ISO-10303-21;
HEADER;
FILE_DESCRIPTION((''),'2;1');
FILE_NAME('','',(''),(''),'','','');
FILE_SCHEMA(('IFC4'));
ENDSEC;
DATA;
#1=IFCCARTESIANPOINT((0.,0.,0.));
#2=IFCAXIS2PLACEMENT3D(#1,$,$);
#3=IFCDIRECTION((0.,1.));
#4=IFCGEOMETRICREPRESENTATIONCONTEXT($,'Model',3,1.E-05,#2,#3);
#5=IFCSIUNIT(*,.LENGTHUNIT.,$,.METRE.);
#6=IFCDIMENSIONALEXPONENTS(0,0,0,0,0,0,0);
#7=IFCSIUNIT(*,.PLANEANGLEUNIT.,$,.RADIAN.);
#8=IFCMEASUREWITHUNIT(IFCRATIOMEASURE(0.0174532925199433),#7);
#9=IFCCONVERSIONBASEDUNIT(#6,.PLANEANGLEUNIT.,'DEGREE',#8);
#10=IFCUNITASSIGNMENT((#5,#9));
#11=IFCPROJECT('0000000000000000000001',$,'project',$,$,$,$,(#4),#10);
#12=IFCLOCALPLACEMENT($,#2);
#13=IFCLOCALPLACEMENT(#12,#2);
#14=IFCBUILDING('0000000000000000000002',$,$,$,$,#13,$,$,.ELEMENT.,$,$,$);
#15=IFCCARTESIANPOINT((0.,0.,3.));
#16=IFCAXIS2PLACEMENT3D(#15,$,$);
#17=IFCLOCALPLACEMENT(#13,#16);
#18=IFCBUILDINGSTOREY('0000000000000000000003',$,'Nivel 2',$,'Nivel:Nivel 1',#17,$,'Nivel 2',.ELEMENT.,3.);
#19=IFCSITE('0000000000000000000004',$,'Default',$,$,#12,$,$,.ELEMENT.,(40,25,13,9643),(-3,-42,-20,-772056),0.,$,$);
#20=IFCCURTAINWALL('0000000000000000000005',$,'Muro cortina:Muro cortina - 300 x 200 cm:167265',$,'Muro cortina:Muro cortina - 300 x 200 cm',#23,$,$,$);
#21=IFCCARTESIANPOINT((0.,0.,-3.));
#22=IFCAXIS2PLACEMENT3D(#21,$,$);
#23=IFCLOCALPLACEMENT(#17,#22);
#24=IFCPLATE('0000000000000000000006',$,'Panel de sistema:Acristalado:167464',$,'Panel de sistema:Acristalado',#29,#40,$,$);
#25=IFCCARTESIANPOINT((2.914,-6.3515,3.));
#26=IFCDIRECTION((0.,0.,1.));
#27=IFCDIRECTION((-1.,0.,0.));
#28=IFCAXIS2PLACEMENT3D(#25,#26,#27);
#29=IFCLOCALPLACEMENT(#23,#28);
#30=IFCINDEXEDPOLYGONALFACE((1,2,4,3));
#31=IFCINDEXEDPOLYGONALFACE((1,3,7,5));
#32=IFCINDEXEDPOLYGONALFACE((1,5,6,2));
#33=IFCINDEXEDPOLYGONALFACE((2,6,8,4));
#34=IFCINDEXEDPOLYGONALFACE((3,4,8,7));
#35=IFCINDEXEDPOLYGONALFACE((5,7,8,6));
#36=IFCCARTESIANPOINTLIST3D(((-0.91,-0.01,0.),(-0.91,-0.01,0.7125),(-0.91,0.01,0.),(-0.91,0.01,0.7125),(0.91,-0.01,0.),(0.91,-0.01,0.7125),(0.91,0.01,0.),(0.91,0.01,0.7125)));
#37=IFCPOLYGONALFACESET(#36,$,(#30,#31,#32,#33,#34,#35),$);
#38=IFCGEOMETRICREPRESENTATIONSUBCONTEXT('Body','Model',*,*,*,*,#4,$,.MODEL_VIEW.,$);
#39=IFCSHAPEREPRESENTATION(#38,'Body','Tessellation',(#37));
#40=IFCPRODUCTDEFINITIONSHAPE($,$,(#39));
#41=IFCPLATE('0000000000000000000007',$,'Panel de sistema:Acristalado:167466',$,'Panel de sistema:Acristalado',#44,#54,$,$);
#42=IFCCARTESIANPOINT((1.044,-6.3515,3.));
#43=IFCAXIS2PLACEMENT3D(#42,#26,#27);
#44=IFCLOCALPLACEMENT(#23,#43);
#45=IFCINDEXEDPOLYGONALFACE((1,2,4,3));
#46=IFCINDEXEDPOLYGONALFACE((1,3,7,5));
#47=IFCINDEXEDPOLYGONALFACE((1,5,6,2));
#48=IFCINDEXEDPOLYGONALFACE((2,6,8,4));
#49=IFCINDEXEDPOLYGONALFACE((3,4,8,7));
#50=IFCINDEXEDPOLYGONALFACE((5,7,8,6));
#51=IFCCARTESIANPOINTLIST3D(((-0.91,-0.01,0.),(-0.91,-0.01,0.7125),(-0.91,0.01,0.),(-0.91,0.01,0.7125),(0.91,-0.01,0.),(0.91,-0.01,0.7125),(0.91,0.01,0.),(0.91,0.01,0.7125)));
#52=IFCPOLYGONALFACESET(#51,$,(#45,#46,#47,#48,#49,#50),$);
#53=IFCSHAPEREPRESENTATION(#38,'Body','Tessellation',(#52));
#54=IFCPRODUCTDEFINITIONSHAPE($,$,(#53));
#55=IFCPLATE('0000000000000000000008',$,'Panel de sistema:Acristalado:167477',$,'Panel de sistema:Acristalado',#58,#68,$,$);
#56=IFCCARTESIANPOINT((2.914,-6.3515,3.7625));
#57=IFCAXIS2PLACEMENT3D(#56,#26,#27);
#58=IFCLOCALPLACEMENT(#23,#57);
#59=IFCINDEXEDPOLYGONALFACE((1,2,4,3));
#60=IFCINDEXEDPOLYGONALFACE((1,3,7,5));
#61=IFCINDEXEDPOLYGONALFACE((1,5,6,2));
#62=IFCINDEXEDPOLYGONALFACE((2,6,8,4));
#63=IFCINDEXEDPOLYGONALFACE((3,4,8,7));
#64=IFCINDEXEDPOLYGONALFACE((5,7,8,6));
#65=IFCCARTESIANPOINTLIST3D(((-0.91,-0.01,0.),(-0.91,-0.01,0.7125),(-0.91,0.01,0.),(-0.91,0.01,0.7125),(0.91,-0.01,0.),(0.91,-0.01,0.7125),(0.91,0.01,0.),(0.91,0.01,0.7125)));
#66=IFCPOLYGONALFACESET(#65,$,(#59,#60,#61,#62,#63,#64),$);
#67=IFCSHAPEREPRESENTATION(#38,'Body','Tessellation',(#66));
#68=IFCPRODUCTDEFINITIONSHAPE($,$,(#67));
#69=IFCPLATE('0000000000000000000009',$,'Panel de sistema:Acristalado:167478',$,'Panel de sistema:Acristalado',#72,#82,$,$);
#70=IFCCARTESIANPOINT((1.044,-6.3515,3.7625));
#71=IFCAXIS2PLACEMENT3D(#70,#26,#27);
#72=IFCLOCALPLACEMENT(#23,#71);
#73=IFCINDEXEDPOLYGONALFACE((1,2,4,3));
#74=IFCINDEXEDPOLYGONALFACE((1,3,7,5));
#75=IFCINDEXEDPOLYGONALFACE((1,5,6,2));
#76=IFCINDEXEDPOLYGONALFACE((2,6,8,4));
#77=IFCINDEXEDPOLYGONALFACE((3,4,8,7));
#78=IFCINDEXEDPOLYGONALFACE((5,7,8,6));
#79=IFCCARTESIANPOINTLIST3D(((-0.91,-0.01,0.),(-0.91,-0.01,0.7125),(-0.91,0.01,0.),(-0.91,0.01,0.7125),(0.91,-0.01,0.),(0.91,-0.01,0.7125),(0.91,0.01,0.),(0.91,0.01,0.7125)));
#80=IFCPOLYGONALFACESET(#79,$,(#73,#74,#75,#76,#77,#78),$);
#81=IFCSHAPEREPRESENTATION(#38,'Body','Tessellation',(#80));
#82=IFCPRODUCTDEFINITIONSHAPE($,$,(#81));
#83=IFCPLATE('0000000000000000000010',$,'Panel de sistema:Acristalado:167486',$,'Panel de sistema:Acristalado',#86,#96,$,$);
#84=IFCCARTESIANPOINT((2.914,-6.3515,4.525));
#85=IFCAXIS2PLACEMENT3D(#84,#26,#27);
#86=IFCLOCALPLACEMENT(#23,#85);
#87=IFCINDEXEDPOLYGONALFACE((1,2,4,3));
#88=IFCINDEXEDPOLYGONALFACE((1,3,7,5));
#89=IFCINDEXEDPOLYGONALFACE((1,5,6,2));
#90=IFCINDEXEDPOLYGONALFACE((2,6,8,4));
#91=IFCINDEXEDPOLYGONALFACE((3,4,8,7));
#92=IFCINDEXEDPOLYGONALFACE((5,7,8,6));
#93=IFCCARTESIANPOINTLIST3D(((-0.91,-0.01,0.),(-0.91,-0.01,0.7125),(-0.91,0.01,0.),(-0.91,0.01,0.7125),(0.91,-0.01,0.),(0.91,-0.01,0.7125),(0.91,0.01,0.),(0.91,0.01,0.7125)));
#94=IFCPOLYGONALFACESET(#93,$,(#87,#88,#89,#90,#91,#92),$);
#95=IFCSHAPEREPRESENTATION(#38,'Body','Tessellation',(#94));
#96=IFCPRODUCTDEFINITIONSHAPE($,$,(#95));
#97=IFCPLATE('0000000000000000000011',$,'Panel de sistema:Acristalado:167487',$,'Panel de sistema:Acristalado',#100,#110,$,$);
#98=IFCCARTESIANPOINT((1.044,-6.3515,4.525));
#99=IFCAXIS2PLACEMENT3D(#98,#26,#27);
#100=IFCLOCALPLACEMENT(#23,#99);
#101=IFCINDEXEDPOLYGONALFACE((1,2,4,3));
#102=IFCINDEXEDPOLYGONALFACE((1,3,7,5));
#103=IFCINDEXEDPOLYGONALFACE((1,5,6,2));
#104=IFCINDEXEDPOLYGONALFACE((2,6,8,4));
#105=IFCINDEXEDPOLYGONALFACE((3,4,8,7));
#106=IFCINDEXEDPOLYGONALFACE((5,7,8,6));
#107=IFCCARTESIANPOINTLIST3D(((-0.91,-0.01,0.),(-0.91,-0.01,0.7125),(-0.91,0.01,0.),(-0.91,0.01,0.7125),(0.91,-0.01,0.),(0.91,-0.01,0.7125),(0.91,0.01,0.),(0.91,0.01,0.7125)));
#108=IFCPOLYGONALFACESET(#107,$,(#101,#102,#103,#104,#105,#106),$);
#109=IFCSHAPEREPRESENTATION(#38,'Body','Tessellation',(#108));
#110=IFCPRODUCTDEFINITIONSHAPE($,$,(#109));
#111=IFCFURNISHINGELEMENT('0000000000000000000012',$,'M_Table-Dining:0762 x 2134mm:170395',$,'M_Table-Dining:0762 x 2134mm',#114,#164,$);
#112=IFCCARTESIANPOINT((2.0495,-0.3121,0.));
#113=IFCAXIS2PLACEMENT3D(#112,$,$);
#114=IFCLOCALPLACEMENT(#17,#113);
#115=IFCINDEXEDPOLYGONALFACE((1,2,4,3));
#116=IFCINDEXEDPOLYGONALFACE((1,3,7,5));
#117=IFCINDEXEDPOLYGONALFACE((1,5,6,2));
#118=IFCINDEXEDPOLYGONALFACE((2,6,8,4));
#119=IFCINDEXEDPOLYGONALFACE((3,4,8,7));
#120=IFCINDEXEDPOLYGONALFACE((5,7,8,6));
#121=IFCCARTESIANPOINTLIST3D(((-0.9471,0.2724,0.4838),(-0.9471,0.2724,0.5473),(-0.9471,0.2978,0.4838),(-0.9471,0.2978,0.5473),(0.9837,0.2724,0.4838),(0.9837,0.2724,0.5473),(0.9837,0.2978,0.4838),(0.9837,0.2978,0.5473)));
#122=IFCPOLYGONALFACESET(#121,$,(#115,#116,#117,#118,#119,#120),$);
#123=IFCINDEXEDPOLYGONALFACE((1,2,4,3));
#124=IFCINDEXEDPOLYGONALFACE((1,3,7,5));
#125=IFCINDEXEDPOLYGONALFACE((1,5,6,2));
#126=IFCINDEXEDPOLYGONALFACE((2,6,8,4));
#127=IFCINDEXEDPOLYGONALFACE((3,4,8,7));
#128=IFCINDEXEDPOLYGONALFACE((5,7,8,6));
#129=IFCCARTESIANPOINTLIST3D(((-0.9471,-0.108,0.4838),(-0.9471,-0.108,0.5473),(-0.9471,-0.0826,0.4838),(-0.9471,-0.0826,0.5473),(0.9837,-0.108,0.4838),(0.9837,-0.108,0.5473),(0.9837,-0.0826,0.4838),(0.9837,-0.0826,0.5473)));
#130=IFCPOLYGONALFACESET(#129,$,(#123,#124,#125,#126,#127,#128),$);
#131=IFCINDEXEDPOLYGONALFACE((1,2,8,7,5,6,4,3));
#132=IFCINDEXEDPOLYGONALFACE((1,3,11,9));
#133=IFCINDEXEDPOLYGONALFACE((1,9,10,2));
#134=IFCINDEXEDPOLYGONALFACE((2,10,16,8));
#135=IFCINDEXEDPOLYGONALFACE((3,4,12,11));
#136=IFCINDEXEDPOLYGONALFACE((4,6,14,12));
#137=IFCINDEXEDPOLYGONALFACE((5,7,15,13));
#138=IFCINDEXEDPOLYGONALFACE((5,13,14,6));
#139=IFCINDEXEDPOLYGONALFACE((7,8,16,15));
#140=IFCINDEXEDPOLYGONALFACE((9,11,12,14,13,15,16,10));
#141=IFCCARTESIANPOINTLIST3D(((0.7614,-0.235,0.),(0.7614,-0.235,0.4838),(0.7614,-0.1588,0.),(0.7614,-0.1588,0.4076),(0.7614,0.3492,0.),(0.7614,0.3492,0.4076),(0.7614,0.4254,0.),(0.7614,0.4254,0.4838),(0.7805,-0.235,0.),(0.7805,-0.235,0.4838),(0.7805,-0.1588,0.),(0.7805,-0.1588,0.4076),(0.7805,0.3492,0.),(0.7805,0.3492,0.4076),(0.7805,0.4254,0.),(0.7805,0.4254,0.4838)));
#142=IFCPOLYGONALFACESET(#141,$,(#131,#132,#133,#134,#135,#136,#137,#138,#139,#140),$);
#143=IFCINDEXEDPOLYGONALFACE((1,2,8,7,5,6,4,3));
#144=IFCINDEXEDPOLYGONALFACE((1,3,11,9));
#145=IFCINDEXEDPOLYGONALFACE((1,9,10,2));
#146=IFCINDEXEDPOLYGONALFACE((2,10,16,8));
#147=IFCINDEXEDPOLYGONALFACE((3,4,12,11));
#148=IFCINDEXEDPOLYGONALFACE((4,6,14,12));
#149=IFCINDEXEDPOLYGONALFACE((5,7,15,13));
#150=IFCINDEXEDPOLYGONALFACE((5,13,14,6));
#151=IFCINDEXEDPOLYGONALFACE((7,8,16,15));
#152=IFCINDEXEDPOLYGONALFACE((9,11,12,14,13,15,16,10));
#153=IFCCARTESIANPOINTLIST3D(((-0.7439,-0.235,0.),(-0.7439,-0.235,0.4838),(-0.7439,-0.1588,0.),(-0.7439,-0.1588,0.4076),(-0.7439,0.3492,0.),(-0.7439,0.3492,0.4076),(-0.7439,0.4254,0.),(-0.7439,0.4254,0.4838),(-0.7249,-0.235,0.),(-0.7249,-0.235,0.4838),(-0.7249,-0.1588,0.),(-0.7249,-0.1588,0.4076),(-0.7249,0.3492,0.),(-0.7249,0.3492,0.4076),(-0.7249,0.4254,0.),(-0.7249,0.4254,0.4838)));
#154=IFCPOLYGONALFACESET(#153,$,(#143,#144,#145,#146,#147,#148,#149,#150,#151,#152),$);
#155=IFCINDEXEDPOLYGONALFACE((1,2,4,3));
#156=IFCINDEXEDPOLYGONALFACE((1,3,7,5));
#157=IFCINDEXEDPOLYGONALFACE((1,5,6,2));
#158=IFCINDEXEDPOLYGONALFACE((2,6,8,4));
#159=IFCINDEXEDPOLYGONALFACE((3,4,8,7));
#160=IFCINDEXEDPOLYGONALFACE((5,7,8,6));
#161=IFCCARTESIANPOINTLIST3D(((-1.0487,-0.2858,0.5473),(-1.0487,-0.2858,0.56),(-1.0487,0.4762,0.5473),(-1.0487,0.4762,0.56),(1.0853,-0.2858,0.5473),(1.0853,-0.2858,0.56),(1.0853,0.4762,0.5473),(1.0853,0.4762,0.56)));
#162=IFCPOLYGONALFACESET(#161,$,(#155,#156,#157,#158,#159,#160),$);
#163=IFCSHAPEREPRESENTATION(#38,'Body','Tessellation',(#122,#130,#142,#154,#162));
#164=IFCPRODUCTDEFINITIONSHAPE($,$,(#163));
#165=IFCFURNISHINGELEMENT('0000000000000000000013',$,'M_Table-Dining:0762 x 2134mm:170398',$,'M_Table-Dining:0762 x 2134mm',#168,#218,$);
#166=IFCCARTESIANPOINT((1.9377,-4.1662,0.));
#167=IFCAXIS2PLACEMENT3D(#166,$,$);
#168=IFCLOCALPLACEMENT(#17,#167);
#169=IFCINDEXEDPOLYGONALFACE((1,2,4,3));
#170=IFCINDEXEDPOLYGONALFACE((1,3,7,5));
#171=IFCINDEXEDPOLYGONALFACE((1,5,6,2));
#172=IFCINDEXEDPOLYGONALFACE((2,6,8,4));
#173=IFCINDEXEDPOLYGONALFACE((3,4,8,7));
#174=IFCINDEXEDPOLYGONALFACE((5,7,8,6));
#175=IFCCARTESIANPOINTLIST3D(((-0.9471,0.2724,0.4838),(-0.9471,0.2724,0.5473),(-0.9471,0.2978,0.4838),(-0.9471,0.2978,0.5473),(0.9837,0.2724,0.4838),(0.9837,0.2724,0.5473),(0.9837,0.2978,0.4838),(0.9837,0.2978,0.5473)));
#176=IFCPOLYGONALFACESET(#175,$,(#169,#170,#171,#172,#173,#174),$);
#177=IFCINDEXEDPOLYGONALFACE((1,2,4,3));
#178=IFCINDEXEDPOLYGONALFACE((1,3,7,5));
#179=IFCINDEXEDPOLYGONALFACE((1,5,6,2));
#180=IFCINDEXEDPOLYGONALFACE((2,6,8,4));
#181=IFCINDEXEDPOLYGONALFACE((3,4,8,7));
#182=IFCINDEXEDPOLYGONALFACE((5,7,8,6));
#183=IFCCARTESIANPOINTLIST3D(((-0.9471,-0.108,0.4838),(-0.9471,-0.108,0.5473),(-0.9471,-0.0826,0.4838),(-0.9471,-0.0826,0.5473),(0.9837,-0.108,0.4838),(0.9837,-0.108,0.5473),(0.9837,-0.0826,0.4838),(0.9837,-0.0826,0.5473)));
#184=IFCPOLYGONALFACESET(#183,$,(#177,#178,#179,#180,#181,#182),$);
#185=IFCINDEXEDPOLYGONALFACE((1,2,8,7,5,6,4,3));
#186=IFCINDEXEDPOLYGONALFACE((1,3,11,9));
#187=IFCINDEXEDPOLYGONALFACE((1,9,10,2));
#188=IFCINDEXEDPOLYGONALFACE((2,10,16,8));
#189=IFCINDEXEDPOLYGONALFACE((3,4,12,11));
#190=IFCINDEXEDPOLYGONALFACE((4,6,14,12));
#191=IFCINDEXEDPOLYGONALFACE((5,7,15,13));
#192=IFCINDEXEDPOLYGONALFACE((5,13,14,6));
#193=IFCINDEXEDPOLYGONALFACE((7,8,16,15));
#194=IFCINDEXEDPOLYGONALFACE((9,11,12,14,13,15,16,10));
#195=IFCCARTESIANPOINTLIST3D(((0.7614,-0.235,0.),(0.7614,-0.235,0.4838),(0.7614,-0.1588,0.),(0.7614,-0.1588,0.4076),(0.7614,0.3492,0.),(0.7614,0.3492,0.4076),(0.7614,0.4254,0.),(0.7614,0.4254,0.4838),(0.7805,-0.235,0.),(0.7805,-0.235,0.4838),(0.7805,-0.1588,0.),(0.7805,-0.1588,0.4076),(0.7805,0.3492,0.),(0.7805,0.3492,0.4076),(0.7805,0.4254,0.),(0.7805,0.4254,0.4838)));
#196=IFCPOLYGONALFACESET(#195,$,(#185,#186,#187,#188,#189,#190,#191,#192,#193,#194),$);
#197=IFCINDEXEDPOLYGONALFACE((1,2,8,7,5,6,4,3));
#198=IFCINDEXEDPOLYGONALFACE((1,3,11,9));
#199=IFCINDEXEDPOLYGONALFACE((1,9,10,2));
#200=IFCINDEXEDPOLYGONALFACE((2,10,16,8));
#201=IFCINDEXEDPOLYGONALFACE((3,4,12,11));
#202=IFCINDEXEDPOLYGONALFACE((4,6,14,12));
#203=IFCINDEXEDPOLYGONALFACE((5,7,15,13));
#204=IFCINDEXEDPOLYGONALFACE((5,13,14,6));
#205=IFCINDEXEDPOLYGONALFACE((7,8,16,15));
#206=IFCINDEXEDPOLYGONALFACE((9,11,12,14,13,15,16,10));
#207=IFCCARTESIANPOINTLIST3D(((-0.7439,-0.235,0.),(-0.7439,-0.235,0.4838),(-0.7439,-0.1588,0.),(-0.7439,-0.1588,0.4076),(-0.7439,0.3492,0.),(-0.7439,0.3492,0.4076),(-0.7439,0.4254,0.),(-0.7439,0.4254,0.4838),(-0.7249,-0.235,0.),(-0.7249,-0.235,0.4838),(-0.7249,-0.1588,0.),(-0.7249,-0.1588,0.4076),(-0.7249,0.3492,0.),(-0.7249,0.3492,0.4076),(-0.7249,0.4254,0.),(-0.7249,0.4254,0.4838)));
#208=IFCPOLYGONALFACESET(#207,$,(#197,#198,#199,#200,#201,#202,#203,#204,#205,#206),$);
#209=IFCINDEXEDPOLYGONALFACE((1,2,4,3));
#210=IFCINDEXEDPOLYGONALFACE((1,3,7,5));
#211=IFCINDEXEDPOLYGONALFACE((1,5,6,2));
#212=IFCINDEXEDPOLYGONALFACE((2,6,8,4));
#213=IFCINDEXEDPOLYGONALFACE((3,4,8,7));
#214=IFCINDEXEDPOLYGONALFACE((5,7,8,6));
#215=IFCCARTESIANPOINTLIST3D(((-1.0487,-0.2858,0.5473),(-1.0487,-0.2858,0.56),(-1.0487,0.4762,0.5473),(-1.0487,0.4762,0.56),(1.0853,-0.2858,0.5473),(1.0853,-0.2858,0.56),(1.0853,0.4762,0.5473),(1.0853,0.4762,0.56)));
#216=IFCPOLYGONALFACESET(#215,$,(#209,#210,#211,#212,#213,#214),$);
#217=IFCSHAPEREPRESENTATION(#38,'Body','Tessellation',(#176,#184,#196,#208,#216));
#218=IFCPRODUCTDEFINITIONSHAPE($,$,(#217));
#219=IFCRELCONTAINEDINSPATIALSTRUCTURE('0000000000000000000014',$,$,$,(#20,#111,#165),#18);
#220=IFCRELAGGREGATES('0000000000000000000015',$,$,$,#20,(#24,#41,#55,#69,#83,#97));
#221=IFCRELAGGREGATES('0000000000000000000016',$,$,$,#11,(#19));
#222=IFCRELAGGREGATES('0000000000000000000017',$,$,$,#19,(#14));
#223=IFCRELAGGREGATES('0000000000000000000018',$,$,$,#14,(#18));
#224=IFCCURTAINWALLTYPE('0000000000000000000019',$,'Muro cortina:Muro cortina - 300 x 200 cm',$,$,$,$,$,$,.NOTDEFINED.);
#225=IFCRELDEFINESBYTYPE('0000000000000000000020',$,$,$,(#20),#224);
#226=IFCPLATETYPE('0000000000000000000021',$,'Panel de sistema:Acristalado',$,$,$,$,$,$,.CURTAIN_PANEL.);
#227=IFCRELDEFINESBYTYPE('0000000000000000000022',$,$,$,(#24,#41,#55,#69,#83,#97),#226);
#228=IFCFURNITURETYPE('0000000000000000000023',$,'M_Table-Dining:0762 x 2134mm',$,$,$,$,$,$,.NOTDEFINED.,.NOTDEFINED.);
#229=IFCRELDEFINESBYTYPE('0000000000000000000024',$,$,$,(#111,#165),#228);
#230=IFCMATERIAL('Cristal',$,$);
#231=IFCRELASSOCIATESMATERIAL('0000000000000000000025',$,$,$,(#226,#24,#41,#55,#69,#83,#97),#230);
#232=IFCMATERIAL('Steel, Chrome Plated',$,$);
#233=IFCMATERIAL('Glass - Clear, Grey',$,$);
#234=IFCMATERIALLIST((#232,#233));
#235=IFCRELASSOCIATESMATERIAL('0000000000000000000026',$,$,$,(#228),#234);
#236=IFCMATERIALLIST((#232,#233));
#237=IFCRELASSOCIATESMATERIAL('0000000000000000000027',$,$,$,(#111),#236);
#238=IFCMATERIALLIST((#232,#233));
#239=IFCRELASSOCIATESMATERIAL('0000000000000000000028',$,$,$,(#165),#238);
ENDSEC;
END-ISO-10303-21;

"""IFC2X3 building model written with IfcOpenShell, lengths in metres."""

from ifc_helpers import new_model, entity, si_unit, converted_unit, direction, frame, frame_2d, origin, origin_2d_with_axis, place, context, subcontext, project, spatial, polyline, rectangle, outline, extrude, source, transform, mapped, material, material_list, type_object, type_shapes, element, aggregate, save


model = new_model("IFC2X3")

# Units and contexts
model_context = context("Model", 3, precision=1e-05, world=origin(), true_north=direction((0.0, 1.0)))
body_context = subcontext(model_context, "Body", "Model", "MODEL_VIEW")
ifc_project = project(units=[si_unit("LENGTHUNIT", "METRE"), converted_unit("PLANEANGLEUNIT", "DEGREE", entity("IfcRatioMeasure", 0.0174532925199433), si_unit("PLANEANGLEUNIT", "RADIAN"), dimensions=[0, 0, 0, 0, 0, 0, 0])], contexts=[model_context])

# Site, building, storey
site_placement = place(None, origin())
site = spatial("IfcSite", under=ifc_project, at=site_placement, Name="Default", CompositionType="ELEMENT", RefLatitude=(40, 25, 13, 9643), RefLongitude=(-3, -42, -20, -772056), RefElevation=0.0)
building_placement = place(site_placement, origin())
building = spatial("IfcBuilding", under=site, at=building_placement, CompositionType="ELEMENT")
storey_placement = place(building_placement, frame((0.0, 0.0, 3.0)))
storey = spatial("IfcBuildingStorey", under=building, at=storey_placement, Name="Nivel 2", ObjectType="Nivel:Nivel 1", LongName="Nivel 2", CompositionType="ELEMENT", Elevation=3.0)

# Curtain wall, plates
curtain_wall_type = type_object("IfcCurtainWallType", Name="Muro cortina:Muro cortina - 300 x 200 cm", PredefinedType="NOTDEFINED")
curtain_wall_placement = place(storey_placement, frame((0.0, 0.0, -3.0)))
curtain_wall = element("IfcCurtainWall", 1, at=curtain_wall_placement, inside=storey, type_object=curtain_wall_type, Name="Muro cortina:Muro cortina - 300 x 200 cm:167265", ObjectType="Muro cortina:Muro cortina - 300 x 200 cm")
ifc_material_1 = material(Name="Cristal")
plate_type = type_object("IfcPlateType", Name="Panel de sistema:Acristalado", PredefinedType="CURTAIN_PANEL", material=ifc_material_1)
shared_shape_1 = source(origin(), body_context, "Body", "SweptSolid", [
    extrude(rectangle(XDim=0.02, YDim=1.82, at=origin_2d_with_axis()), frame((0.0, 0.0, 0.0), z_axis=(0.0, 0.0, 1.0), x_axis=(0.0, 1.0, 0.0)), (0.0, 0.0, 1.0), 0.7125),
])
type_shapes(plate_type, [shared_shape_1])
plate_1_placement = place(curtain_wall_placement, frame((2.914, -6.3515, 3.0), z_axis=(0.0, 0.0, 1.0), x_axis=(-1.0, 0.0, 0.0)))
plate_1 = element("IfcPlate", 2, at=plate_1_placement, type_object=plate_type, material=ifc_material_1, Name="Panel de sistema:Acristalado:167464", ObjectType="Panel de sistema:Acristalado", context=body_context, shape_type="MappedRepresentation", body=[
    mapped(shared_shape_1, transform((0.0, 0.0, 0.0), scale=1.0)),
])
plate_2_placement = place(curtain_wall_placement, frame((1.044, -6.3515, 3.0), z_axis=(0.0, 0.0, 1.0), x_axis=(-1.0, 0.0, 0.0)))
plate_2 = element("IfcPlate", 3, at=plate_2_placement, type_object=plate_type, material=ifc_material_1, Name="Panel de sistema:Acristalado:167466", ObjectType="Panel de sistema:Acristalado", context=body_context, shape_type="MappedRepresentation", body=[
    mapped(shared_shape_1, transform((0.0, 0.0, 0.0), scale=1.0)),
])
plate_3_placement = place(curtain_wall_placement, frame((2.914, -6.3515, 3.7625), z_axis=(0.0, 0.0, 1.0), x_axis=(-1.0, 0.0, 0.0)))
plate_3 = element("IfcPlate", 4, at=plate_3_placement, type_object=plate_type, material=ifc_material_1, Name="Panel de sistema:Acristalado:167477", ObjectType="Panel de sistema:Acristalado", context=body_context, shape_type="MappedRepresentation", body=[
    mapped(shared_shape_1, transform((0.0, 0.0, 0.0), scale=1.0)),
])
plate_4_placement = place(curtain_wall_placement, frame((1.044, -6.3515, 3.7625), z_axis=(0.0, 0.0, 1.0), x_axis=(-1.0, 0.0, 0.0)))
plate_4 = element("IfcPlate", 5, at=plate_4_placement, type_object=plate_type, material=ifc_material_1, Name="Panel de sistema:Acristalado:167478", ObjectType="Panel de sistema:Acristalado", context=body_context, shape_type="MappedRepresentation", body=[
    mapped(shared_shape_1, transform((0.0, 0.0, 0.0), scale=1.0)),
])
plate_5_placement = place(curtain_wall_placement, frame((2.914, -6.3515, 4.525), z_axis=(0.0, 0.0, 1.0), x_axis=(-1.0, 0.0, 0.0)))
plate_5 = element("IfcPlate", 6, at=plate_5_placement, type_object=plate_type, material=ifc_material_1, Name="Panel de sistema:Acristalado:167486", ObjectType="Panel de sistema:Acristalado", context=body_context, shape_type="MappedRepresentation", body=[
    mapped(shared_shape_1, transform((0.0, 0.0, 0.0), scale=1.0)),
])
plate_6_placement = place(curtain_wall_placement, frame((1.044, -6.3515, 4.525), z_axis=(0.0, 0.0, 1.0), x_axis=(-1.0, 0.0, 0.0)))
plate_6 = element("IfcPlate", 7, at=plate_6_placement, type_object=plate_type, material=ifc_material_1, Name="Panel de sistema:Acristalado:167487", ObjectType="Panel de sistema:Acristalado", context=body_context, shape_type="MappedRepresentation", body=[
    mapped(shared_shape_1, transform((0.0, 0.0, 0.0), scale=1.0)),
])
aggregate(curtain_wall, [plate_1, plate_2, plate_3, plate_4, plate_5, plate_6])

# Furnishing elements
ifc_material_2 = material(Name="Steel, Chrome Plated")
ifc_material_3 = material(Name="Glass - Clear, Grey")
ifc_material_list_1 = material_list([ifc_material_2, ifc_material_3])
ifc_material_list_2 = material_list([ifc_material_2, ifc_material_3])
furniture_type = type_object("IfcFurnitureType", Name="M_Table-Dining:0762 x 2134mm", material=ifc_material_list_2)
shared_shape_2 = source(origin(), body_context, "Body", "SweptSolid", [
    extrude(rectangle(XDim=1.9308, YDim=0.0254, at=frame_2d((0.0, 0.0), x_axis=(1.0, 0.0))), frame((0.0183, 0.2851, 0.4838), z_axis=(0.0, 0.0, 1.0), x_axis=(-1.0, 0.0, 0.0)), (0.0, 0.0, 1.0), 0.0635),
    extrude(rectangle(XDim=1.9308, YDim=0.0254, at=origin_2d_with_axis()), frame((0.0183, -0.0953, 0.4838), z_axis=(0.0, 0.0, 1.0), x_axis=(-1.0, 0.0, 0.0)), (0.0, 0.0, 1.0), 0.0635),
    extrude(outline(polyline([(-0.2228, -0.3302), (0.2609, -0.3302), (0.2609, 0.3302), (-0.2228, 0.3302), (-0.2228, 0.254), (0.1847, 0.254), (0.1847, -0.254), (-0.2228, -0.254), (-0.2228, -0.3302)])), frame((0.7614, 0.0952, 0.2228), z_axis=(1.0, 0.0, 0.0), x_axis=(0.0, 0.0, 1.0)), (0.0, 0.0, 1.0), 0.0191),
    extrude(outline(polyline([(-0.3302, -0.261), (0.3302, -0.261), (0.3302, 0.2228), (0.254, 0.2228), (0.254, -0.1847), (-0.254, -0.1847), (-0.254, 0.2228), (-0.3302, 0.2228), (-0.3302, -0.261)])), frame((-0.7439, 0.0952, 0.2228), z_axis=(1.0, 0.0, 0.0), x_axis=(0.0, -1.0, 0.0)), (0.0, 0.0, 1.0), 0.0191),
    extrude(rectangle(XDim=2.134, YDim=0.762, at=origin_2d_with_axis()), frame((0.0183, 0.0952, 0.5473), z_axis=(0.0, 0.0, 1.0), x_axis=(-1.0, 0.0, 0.0)), (0.0, 0.0, 1.0), 0.0127),
])
type_shapes(furniture_type, [shared_shape_2])
furnishing_1_placement = place(storey_placement, frame((2.0495, -0.3121, 0.0)))
element("IfcFurnishingElement", 8, at=furnishing_1_placement, inside=storey, type_object=furniture_type, material=ifc_material_list_1, Name="M_Table-Dining:0762 x 2134mm:170395", ObjectType="M_Table-Dining:0762 x 2134mm", context=body_context, shape_type="MappedRepresentation", body=[
    mapped(shared_shape_2, transform((0.0, 0.0, 0.0), scale=1.0)),
])
ifc_material_list_3 = material_list([ifc_material_2, ifc_material_3])
furnishing_2_placement = place(storey_placement, frame((1.9377, -4.1662, 0.0)))
element("IfcFurnishingElement", 9, at=furnishing_2_placement, inside=storey, type_object=furniture_type, material=ifc_material_list_3, Name="M_Table-Dining:0762 x 2134mm:170398", ObjectType="M_Table-Dining:0762 x 2134mm", context=body_context, shape_type="MappedRepresentation", body=[
    mapped(shared_shape_2, transform((0.0, 0.0, 0.0), scale=1.0)),
])

save(model, "model.ifc")
